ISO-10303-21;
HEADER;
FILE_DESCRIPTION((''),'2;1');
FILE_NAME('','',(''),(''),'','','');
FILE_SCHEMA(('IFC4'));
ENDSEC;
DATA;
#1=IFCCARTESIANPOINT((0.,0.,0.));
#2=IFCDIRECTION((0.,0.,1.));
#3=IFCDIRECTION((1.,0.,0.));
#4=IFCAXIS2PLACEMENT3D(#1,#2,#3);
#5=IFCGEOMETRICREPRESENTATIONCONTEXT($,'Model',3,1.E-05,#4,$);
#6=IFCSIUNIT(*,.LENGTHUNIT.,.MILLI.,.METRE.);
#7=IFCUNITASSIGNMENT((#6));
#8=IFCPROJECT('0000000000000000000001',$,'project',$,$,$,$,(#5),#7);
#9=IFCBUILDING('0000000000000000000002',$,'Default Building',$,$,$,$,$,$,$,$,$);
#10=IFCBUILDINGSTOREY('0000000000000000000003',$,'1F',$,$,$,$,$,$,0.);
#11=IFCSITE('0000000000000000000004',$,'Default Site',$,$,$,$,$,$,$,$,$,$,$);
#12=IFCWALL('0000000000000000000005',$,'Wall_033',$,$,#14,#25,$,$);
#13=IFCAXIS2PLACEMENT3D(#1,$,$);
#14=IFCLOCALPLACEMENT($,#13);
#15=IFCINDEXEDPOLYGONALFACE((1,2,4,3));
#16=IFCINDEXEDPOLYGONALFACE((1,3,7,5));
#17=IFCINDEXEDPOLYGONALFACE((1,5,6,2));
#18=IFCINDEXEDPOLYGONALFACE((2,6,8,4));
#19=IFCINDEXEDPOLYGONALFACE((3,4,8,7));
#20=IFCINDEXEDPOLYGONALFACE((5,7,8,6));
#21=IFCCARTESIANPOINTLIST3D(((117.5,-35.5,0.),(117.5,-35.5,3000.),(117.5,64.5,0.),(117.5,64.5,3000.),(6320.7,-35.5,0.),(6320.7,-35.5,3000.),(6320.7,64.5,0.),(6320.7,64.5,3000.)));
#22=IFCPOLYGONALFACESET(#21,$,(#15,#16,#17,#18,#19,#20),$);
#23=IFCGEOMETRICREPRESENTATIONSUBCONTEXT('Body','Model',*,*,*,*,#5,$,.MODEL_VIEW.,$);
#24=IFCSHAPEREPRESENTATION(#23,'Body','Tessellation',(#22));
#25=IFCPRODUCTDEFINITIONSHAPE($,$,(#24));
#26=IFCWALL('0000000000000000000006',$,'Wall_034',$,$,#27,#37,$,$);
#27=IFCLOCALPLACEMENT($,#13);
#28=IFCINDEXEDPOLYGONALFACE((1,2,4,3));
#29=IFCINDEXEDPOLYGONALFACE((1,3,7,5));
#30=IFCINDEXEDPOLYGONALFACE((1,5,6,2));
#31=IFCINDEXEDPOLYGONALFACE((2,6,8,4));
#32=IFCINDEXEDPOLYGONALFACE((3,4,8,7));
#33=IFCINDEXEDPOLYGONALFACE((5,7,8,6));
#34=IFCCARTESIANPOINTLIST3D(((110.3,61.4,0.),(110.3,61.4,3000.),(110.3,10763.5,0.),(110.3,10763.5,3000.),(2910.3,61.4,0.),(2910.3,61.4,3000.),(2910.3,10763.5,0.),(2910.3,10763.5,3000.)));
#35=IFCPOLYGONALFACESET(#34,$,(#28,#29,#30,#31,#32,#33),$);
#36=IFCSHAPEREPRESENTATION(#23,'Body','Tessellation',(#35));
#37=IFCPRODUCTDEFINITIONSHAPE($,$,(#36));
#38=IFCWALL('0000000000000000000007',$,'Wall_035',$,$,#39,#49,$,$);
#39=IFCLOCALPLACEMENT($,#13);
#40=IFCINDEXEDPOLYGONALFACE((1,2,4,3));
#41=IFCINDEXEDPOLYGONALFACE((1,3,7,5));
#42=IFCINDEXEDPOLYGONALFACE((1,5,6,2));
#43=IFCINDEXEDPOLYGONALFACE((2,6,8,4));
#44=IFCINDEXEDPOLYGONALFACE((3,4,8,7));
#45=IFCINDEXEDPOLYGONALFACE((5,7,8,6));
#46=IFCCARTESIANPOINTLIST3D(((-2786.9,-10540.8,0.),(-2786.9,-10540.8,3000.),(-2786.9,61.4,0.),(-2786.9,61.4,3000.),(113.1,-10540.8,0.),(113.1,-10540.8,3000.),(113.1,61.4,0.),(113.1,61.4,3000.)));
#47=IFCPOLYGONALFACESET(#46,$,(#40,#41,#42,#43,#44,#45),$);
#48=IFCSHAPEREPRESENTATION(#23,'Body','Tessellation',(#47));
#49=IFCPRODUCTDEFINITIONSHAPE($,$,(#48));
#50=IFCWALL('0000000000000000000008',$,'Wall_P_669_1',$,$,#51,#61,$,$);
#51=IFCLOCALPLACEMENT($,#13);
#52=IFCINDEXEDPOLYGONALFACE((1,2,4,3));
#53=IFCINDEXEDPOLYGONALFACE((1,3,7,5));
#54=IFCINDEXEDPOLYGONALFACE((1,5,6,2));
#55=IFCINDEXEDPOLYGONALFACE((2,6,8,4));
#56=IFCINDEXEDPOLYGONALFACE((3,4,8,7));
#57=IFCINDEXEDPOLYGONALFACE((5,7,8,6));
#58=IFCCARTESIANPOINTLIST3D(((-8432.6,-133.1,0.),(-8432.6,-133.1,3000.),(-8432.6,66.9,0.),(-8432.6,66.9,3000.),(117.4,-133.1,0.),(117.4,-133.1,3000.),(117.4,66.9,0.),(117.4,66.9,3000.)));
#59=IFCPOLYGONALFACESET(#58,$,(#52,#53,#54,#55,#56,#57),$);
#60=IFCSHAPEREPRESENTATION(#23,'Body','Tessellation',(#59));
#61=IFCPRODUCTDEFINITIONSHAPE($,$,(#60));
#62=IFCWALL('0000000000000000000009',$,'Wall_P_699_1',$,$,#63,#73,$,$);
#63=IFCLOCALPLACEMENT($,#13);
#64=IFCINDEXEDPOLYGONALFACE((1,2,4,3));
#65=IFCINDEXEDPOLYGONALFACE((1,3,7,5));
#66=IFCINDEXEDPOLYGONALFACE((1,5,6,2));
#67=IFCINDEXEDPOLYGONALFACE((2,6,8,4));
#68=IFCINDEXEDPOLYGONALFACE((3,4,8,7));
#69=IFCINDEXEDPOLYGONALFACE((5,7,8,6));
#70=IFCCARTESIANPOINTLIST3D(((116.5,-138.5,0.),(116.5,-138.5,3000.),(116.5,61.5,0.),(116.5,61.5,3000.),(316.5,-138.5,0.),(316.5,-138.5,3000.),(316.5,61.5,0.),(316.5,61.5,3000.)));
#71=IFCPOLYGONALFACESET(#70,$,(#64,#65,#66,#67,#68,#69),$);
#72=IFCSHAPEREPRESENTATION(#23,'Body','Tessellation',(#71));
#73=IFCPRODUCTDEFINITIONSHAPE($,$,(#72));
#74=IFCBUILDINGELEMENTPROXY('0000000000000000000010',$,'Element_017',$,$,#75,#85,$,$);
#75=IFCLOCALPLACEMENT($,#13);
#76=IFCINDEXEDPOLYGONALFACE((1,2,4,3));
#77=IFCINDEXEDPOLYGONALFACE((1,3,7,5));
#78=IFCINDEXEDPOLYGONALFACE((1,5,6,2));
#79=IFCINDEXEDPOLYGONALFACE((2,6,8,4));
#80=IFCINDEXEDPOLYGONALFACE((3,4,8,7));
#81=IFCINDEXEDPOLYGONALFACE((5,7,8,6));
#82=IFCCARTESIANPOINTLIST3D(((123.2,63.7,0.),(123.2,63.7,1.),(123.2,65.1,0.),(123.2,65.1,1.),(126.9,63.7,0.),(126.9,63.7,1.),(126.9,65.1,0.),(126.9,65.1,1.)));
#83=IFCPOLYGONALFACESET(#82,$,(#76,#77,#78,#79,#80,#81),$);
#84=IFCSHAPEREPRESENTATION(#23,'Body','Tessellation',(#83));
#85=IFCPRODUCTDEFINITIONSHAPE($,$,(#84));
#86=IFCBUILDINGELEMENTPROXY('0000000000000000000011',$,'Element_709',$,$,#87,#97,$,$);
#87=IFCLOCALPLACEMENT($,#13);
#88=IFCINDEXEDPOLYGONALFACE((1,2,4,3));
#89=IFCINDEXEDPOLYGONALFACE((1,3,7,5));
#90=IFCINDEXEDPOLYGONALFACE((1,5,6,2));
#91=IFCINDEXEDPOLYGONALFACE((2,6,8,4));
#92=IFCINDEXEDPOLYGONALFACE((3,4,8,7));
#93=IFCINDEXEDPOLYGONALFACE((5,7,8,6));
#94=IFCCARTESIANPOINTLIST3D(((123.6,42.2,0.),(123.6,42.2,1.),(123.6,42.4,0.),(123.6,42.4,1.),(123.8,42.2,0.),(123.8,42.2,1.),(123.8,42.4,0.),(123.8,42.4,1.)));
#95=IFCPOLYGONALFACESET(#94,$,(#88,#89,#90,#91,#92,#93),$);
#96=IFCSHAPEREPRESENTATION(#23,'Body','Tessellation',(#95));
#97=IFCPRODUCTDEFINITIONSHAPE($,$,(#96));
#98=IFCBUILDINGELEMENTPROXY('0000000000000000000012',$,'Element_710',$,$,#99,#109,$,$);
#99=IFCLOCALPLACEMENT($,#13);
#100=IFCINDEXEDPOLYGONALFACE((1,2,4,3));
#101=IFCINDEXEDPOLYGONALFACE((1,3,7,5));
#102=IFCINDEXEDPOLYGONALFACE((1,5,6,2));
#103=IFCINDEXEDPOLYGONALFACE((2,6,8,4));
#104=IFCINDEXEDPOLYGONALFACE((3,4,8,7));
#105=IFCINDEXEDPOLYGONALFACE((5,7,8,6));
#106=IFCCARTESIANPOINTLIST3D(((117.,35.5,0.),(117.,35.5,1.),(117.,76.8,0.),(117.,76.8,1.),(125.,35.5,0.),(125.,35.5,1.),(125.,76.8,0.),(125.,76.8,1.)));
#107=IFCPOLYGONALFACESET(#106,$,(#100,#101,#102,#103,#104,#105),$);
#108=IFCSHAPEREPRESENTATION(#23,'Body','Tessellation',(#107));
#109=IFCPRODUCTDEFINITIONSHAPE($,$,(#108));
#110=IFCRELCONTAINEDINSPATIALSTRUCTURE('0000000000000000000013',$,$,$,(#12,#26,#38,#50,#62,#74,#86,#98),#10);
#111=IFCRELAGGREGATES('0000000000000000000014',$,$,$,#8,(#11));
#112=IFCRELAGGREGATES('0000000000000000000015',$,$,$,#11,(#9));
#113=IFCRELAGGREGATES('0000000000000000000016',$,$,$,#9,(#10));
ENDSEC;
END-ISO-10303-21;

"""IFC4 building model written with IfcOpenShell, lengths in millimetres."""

from ifc_helpers import new_model, si_unit, frame, origin, origin_with_axes, place, context, subcontext, project, spatial, polyline, indexed_curve, rectangle, outline, extrude, element, save


model = new_model("IFC4")

# Units and contexts
model_context = context("Model", 3, precision=1e-05, world=origin_with_axes())
body_context = subcontext(model_context, "Body", "Model", "MODEL_VIEW")
ifc_project = project(units=[si_unit("LENGTHUNIT", "METRE", prefix="MILLI")], contexts=[model_context])

# Site, building, storey
site = spatial("IfcSite", under=ifc_project, Name="Default Site")
building = spatial("IfcBuilding", under=site, Name="Default Building")
storey = spatial("IfcBuildingStorey", under=building, Name="1F", Elevation=0.0)

# Walls
wall_1_placement = place(None, frame((117.5, 64.5, 0.0), z_axis=(0.0, 0.0, 1.0), x_axis=(0.0, -1.0, 0.0)))
element("IfcWall", 1, at=wall_1_placement, inside=storey, Name="Wall_033", context=body_context, shape_type="SweptSolid", body=[
    extrude(outline(indexed_curve([(0.0, 0.0), (0.0, 6203.2), (100.0, 6203.2), (100.0, 0.0), (0.0, 0.0)], self_intersect=False)), origin_with_axes(), (0.0, 0.0, 1.0), 3000.0),
])
wall_2_placement = place(None, frame((110.3, 61.4, 0.0), z_axis=(0.0, 0.0, 1.0), x_axis=(1.0, 0.0, 0.0)))
element("IfcWall", 2, at=wall_2_placement, inside=storey, Name="Wall_034", context=body_context, shape_type="SweptSolid", body=[
    extrude(outline(indexed_curve([(0.0, 0.0), (0.0, 10702.2), (2800.0, 10702.2), (2800.0, 0.0), (0.0, 0.0)], self_intersect=False)), origin_with_axes(), (0.0, 0.0, 1.0), 3000.0),
])
wall_3_placement = place(None, frame((113.1, 61.4, 0.0), z_axis=(0.0, 0.0, 1.0), x_axis=(-1.0, 0.0, 0.0)))
element("IfcWall", 3, at=wall_3_placement, inside=storey, Name="Wall_035", context=body_context, shape_type="SweptSolid", body=[
    extrude(outline(indexed_curve([(0.0, 0.0), (0.0, 10602.2), (2900.0, 10602.2), (2900.0, 0.0), (0.0, 0.0)], self_intersect=False)), origin_with_axes(), (0.0, 0.0, 1.0), 3000.0),
])
wall_4_placement = place(None, frame((117.4, 66.9, 0.0), z_axis=(0.0, 0.0, 1.0), x_axis=(-1.0, 0.0, 0.0)))
element("IfcWall", 4, at=wall_4_placement, inside=storey, Name="Wall_P_669_1", context=body_context, shape_type="SweptSolid", body=[
    extrude(outline(indexed_curve([(0.0, 0.0), (0.0, 200.0), (8550.0, 200.0), (8550.0, 0.0), (0.0, 0.0)], self_intersect=False)), origin_with_axes(), (0.0, 0.0, 1.0), 3000.0),
])
wall_5_placement = place(None, frame((116.5, 61.5, 0.0), z_axis=(0.0, 0.0, 1.0), x_axis=(0.0, -1.0, 0.0)))
element("IfcWall", 5, at=wall_5_placement, inside=storey, Name="Wall_P_699_1", context=body_context, shape_type="SweptSolid", body=[
    extrude(outline(indexed_curve([(0.0, 0.0), (0.0, 200.0), (200.0, 200.0), (200.0, 0.0), (0.0, 0.0)], self_intersect=False)), origin_with_axes(), (0.0, 0.0, 1.0), 3000.0),
])

# Building element proxies
proxy_1_placement = place(None, frame((125.1, 64.4, 0.0), z_axis=(0.0, 0.0, 1.0), x_axis=(1.0, 0.0, 0.0)))
element("IfcBuildingElementProxy", 6, at=proxy_1_placement, inside=storey, Name="Element_017", context=body_context, shape_type="SweptSolid", body=[
    extrude(rectangle(XDim=3.7, YDim=1.4), origin(), (0.0, 0.0, 1.0), 1.0),
])
proxy_2_placement = place(None, frame((123.7, 42.3, 0.0), z_axis=(0.0, 0.0, 1.0), x_axis=(1.0, 0.0, 0.0)))
element("IfcBuildingElementProxy", 7, at=proxy_2_placement, inside=storey, Name="Element_709", context=body_context, shape_type="SweptSolid", body=[
    extrude(outline(polyline([(-0.1, 0.1), (0.1, 0.1), (0.1, -0.1), (-0.1, -0.1), (-0.1, 0.1)])), origin(), (0.0, 0.0, 1.0), 1.0),
])
proxy_3_placement = place(None, frame((121.0, 56.2, 0.0), z_axis=(0.0, 0.0, 1.0), x_axis=(1.0, 0.0, 0.0)))
element("IfcBuildingElementProxy", 8, at=proxy_3_placement, inside=storey, Name="Element_710", context=body_context, shape_type="SweptSolid", body=[
    extrude(rectangle(XDim=8.0, YDim=41.3), origin(), (0.0, 0.0, 1.0), 1.0),
])

save(model, "model.ifc")
